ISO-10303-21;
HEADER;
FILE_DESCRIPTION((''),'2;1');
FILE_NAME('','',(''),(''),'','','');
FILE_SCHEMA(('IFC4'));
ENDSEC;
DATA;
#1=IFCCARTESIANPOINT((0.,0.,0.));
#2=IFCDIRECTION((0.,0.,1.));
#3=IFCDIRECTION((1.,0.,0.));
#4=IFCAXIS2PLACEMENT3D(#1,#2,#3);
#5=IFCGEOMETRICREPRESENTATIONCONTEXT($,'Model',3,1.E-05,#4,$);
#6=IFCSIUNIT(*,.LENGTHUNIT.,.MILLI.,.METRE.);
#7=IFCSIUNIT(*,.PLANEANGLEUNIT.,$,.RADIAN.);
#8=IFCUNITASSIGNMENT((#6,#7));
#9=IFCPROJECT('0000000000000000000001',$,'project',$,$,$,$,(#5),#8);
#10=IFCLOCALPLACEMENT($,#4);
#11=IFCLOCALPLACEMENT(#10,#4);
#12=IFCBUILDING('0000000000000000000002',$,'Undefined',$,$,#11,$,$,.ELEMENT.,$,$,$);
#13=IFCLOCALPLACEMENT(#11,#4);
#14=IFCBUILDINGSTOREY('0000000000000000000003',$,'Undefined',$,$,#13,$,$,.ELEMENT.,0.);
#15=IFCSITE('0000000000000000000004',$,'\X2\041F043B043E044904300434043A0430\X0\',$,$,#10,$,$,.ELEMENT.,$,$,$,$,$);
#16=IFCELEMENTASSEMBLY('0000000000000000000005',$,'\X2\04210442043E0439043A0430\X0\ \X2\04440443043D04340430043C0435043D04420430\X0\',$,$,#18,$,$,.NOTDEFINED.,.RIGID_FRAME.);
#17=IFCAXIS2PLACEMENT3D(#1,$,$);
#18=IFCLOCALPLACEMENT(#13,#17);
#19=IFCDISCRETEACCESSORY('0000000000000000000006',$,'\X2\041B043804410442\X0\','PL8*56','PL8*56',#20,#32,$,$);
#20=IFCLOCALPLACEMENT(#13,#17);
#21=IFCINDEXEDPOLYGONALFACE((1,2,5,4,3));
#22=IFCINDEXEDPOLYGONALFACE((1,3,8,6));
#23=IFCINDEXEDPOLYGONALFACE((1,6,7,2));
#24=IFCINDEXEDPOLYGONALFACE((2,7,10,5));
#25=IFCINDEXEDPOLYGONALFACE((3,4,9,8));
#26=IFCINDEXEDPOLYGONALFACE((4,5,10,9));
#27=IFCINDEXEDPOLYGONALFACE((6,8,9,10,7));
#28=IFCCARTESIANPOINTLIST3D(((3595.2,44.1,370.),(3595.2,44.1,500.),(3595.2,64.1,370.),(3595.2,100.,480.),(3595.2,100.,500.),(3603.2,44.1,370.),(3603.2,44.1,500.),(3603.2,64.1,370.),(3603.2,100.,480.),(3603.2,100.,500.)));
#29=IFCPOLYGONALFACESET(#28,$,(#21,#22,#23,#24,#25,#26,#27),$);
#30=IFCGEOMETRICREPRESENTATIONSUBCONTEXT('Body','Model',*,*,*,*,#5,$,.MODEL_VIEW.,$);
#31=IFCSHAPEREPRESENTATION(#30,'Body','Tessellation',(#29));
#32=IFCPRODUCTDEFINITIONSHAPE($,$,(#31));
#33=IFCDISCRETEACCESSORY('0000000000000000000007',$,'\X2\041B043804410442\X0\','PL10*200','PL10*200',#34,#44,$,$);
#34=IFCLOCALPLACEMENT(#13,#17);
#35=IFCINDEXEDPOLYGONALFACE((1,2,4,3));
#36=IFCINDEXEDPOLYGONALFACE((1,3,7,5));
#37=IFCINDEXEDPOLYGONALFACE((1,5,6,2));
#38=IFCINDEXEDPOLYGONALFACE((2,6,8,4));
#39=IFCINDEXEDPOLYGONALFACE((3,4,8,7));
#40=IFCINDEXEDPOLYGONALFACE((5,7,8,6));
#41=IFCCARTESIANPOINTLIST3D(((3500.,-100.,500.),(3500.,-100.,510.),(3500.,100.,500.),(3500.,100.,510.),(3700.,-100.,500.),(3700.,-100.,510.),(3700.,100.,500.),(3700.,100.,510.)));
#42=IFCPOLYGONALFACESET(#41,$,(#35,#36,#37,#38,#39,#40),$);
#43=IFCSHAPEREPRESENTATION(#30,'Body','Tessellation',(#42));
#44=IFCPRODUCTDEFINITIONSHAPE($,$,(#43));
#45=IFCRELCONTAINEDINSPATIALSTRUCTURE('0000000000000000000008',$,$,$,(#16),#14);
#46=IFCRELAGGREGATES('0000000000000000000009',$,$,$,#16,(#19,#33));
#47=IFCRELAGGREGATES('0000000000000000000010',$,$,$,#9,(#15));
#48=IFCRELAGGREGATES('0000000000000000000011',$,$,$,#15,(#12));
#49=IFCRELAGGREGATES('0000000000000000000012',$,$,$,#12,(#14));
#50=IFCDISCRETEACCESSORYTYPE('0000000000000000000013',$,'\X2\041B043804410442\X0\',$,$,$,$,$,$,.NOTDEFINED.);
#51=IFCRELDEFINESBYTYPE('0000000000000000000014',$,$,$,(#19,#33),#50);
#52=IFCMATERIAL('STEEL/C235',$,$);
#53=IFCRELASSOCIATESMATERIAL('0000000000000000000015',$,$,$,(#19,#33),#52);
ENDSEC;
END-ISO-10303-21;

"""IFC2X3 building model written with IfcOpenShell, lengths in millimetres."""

from ifc_helpers import new_model, si_unit, frame, origin_with_axes, place, context, subcontext, project, spatial, polyline, outline, extrude, material, type_object, element, aggregate, save


model = new_model("IFC2X3")

# Units and contexts
model_context = context("Model", 3, precision=1e-05, world=origin_with_axes())
body_context = subcontext(model_context, "Body", "Model", "MODEL_VIEW")
ifc_project = project(units=[si_unit("LENGTHUNIT", "METRE", prefix="MILLI"), si_unit("PLANEANGLEUNIT", "RADIAN")], contexts=[model_context])

# Site, building, storey
site_placement = place(None, origin_with_axes())
site = spatial("IfcSite", under=ifc_project, at=site_placement, Name="Площадка", CompositionType="ELEMENT")
building_placement = place(site_placement, origin_with_axes())
building = spatial("IfcBuilding", under=site, at=building_placement, Name="Undefined", CompositionType="ELEMENT")
storey_placement = place(building_placement, origin_with_axes())
storey = spatial("IfcBuildingStorey", under=building, at=storey_placement, Name="Undefined", CompositionType="ELEMENT", Elevation=0.0)

# Shared definitions
ifc_material_1 = material(Name="STEEL/C235")

# Shared definitions
discrete_accessory_type = type_object("IfcDiscreteAccessoryType", Name="Лист")

# Element assembly, discrete accessories
assembly_1_placement = place(storey_placement, origin_with_axes())
assembly_1 = element("IfcElementAssembly", 1, at=assembly_1_placement, inside=storey, Name="Стойка фундамента", AssemblyPlace="NOTDEFINED", PredefinedType="RIGID_FRAME")
discrete_accessory_1_placement = place(assembly_1_placement, frame((3599.2, 44.1, 500.0), z_axis=(-1.0, 0.0, 0.0), x_axis=(0.0, 1.0, 0.0)))
discrete_accessory_1 = element("IfcDiscreteAccessory", 2, at=discrete_accessory_1_placement, type_object=discrete_accessory_type, material=ifc_material_1, Name="Лист", Description="PL8*56", ObjectType="PL8*56", context=body_context, shape_type="SweptSolid", body=[
    extrude(outline(polyline([(0.0, 0.0), (55.9, 0.0), (55.9, 20.0), (20.0, 130.0), (0.0, 130.0), (0.0, 0.0)])), frame((0.0, 0.0, -4.0), z_axis=(0.0, 0.0, 1.0), x_axis=(1.0, 0.0, 0.0)), (0.0, 0.0, 1.0), 8.0),
])
discrete_accessory_2_placement = place(assembly_1_placement, frame((3500.0, -100.0, 505.0), z_axis=(0.0, 0.0, 1.0), x_axis=(1.0, 0.0, 0.0)))
discrete_accessory_2 = element("IfcDiscreteAccessory", 3, at=discrete_accessory_2_placement, type_object=discrete_accessory_type, material=ifc_material_1, Name="Лист", Description="PL10*200", ObjectType="PL10*200", context=body_context, shape_type="SweptSolid", body=[
    extrude(outline(polyline([(0.0, 0.0), (200.0, 0.0), (200.0, 200.0), (0.0, 200.0), (0.0, 0.0)])), frame((0.0, 0.0, -5.0), z_axis=(0.0, 0.0, 1.0), x_axis=(1.0, 0.0, 0.0)), (0.0, 0.0, 1.0), 10.0),
])
aggregate(assembly_1, [discrete_accessory_1, discrete_accessory_2])

save(model, "model.ifc")
